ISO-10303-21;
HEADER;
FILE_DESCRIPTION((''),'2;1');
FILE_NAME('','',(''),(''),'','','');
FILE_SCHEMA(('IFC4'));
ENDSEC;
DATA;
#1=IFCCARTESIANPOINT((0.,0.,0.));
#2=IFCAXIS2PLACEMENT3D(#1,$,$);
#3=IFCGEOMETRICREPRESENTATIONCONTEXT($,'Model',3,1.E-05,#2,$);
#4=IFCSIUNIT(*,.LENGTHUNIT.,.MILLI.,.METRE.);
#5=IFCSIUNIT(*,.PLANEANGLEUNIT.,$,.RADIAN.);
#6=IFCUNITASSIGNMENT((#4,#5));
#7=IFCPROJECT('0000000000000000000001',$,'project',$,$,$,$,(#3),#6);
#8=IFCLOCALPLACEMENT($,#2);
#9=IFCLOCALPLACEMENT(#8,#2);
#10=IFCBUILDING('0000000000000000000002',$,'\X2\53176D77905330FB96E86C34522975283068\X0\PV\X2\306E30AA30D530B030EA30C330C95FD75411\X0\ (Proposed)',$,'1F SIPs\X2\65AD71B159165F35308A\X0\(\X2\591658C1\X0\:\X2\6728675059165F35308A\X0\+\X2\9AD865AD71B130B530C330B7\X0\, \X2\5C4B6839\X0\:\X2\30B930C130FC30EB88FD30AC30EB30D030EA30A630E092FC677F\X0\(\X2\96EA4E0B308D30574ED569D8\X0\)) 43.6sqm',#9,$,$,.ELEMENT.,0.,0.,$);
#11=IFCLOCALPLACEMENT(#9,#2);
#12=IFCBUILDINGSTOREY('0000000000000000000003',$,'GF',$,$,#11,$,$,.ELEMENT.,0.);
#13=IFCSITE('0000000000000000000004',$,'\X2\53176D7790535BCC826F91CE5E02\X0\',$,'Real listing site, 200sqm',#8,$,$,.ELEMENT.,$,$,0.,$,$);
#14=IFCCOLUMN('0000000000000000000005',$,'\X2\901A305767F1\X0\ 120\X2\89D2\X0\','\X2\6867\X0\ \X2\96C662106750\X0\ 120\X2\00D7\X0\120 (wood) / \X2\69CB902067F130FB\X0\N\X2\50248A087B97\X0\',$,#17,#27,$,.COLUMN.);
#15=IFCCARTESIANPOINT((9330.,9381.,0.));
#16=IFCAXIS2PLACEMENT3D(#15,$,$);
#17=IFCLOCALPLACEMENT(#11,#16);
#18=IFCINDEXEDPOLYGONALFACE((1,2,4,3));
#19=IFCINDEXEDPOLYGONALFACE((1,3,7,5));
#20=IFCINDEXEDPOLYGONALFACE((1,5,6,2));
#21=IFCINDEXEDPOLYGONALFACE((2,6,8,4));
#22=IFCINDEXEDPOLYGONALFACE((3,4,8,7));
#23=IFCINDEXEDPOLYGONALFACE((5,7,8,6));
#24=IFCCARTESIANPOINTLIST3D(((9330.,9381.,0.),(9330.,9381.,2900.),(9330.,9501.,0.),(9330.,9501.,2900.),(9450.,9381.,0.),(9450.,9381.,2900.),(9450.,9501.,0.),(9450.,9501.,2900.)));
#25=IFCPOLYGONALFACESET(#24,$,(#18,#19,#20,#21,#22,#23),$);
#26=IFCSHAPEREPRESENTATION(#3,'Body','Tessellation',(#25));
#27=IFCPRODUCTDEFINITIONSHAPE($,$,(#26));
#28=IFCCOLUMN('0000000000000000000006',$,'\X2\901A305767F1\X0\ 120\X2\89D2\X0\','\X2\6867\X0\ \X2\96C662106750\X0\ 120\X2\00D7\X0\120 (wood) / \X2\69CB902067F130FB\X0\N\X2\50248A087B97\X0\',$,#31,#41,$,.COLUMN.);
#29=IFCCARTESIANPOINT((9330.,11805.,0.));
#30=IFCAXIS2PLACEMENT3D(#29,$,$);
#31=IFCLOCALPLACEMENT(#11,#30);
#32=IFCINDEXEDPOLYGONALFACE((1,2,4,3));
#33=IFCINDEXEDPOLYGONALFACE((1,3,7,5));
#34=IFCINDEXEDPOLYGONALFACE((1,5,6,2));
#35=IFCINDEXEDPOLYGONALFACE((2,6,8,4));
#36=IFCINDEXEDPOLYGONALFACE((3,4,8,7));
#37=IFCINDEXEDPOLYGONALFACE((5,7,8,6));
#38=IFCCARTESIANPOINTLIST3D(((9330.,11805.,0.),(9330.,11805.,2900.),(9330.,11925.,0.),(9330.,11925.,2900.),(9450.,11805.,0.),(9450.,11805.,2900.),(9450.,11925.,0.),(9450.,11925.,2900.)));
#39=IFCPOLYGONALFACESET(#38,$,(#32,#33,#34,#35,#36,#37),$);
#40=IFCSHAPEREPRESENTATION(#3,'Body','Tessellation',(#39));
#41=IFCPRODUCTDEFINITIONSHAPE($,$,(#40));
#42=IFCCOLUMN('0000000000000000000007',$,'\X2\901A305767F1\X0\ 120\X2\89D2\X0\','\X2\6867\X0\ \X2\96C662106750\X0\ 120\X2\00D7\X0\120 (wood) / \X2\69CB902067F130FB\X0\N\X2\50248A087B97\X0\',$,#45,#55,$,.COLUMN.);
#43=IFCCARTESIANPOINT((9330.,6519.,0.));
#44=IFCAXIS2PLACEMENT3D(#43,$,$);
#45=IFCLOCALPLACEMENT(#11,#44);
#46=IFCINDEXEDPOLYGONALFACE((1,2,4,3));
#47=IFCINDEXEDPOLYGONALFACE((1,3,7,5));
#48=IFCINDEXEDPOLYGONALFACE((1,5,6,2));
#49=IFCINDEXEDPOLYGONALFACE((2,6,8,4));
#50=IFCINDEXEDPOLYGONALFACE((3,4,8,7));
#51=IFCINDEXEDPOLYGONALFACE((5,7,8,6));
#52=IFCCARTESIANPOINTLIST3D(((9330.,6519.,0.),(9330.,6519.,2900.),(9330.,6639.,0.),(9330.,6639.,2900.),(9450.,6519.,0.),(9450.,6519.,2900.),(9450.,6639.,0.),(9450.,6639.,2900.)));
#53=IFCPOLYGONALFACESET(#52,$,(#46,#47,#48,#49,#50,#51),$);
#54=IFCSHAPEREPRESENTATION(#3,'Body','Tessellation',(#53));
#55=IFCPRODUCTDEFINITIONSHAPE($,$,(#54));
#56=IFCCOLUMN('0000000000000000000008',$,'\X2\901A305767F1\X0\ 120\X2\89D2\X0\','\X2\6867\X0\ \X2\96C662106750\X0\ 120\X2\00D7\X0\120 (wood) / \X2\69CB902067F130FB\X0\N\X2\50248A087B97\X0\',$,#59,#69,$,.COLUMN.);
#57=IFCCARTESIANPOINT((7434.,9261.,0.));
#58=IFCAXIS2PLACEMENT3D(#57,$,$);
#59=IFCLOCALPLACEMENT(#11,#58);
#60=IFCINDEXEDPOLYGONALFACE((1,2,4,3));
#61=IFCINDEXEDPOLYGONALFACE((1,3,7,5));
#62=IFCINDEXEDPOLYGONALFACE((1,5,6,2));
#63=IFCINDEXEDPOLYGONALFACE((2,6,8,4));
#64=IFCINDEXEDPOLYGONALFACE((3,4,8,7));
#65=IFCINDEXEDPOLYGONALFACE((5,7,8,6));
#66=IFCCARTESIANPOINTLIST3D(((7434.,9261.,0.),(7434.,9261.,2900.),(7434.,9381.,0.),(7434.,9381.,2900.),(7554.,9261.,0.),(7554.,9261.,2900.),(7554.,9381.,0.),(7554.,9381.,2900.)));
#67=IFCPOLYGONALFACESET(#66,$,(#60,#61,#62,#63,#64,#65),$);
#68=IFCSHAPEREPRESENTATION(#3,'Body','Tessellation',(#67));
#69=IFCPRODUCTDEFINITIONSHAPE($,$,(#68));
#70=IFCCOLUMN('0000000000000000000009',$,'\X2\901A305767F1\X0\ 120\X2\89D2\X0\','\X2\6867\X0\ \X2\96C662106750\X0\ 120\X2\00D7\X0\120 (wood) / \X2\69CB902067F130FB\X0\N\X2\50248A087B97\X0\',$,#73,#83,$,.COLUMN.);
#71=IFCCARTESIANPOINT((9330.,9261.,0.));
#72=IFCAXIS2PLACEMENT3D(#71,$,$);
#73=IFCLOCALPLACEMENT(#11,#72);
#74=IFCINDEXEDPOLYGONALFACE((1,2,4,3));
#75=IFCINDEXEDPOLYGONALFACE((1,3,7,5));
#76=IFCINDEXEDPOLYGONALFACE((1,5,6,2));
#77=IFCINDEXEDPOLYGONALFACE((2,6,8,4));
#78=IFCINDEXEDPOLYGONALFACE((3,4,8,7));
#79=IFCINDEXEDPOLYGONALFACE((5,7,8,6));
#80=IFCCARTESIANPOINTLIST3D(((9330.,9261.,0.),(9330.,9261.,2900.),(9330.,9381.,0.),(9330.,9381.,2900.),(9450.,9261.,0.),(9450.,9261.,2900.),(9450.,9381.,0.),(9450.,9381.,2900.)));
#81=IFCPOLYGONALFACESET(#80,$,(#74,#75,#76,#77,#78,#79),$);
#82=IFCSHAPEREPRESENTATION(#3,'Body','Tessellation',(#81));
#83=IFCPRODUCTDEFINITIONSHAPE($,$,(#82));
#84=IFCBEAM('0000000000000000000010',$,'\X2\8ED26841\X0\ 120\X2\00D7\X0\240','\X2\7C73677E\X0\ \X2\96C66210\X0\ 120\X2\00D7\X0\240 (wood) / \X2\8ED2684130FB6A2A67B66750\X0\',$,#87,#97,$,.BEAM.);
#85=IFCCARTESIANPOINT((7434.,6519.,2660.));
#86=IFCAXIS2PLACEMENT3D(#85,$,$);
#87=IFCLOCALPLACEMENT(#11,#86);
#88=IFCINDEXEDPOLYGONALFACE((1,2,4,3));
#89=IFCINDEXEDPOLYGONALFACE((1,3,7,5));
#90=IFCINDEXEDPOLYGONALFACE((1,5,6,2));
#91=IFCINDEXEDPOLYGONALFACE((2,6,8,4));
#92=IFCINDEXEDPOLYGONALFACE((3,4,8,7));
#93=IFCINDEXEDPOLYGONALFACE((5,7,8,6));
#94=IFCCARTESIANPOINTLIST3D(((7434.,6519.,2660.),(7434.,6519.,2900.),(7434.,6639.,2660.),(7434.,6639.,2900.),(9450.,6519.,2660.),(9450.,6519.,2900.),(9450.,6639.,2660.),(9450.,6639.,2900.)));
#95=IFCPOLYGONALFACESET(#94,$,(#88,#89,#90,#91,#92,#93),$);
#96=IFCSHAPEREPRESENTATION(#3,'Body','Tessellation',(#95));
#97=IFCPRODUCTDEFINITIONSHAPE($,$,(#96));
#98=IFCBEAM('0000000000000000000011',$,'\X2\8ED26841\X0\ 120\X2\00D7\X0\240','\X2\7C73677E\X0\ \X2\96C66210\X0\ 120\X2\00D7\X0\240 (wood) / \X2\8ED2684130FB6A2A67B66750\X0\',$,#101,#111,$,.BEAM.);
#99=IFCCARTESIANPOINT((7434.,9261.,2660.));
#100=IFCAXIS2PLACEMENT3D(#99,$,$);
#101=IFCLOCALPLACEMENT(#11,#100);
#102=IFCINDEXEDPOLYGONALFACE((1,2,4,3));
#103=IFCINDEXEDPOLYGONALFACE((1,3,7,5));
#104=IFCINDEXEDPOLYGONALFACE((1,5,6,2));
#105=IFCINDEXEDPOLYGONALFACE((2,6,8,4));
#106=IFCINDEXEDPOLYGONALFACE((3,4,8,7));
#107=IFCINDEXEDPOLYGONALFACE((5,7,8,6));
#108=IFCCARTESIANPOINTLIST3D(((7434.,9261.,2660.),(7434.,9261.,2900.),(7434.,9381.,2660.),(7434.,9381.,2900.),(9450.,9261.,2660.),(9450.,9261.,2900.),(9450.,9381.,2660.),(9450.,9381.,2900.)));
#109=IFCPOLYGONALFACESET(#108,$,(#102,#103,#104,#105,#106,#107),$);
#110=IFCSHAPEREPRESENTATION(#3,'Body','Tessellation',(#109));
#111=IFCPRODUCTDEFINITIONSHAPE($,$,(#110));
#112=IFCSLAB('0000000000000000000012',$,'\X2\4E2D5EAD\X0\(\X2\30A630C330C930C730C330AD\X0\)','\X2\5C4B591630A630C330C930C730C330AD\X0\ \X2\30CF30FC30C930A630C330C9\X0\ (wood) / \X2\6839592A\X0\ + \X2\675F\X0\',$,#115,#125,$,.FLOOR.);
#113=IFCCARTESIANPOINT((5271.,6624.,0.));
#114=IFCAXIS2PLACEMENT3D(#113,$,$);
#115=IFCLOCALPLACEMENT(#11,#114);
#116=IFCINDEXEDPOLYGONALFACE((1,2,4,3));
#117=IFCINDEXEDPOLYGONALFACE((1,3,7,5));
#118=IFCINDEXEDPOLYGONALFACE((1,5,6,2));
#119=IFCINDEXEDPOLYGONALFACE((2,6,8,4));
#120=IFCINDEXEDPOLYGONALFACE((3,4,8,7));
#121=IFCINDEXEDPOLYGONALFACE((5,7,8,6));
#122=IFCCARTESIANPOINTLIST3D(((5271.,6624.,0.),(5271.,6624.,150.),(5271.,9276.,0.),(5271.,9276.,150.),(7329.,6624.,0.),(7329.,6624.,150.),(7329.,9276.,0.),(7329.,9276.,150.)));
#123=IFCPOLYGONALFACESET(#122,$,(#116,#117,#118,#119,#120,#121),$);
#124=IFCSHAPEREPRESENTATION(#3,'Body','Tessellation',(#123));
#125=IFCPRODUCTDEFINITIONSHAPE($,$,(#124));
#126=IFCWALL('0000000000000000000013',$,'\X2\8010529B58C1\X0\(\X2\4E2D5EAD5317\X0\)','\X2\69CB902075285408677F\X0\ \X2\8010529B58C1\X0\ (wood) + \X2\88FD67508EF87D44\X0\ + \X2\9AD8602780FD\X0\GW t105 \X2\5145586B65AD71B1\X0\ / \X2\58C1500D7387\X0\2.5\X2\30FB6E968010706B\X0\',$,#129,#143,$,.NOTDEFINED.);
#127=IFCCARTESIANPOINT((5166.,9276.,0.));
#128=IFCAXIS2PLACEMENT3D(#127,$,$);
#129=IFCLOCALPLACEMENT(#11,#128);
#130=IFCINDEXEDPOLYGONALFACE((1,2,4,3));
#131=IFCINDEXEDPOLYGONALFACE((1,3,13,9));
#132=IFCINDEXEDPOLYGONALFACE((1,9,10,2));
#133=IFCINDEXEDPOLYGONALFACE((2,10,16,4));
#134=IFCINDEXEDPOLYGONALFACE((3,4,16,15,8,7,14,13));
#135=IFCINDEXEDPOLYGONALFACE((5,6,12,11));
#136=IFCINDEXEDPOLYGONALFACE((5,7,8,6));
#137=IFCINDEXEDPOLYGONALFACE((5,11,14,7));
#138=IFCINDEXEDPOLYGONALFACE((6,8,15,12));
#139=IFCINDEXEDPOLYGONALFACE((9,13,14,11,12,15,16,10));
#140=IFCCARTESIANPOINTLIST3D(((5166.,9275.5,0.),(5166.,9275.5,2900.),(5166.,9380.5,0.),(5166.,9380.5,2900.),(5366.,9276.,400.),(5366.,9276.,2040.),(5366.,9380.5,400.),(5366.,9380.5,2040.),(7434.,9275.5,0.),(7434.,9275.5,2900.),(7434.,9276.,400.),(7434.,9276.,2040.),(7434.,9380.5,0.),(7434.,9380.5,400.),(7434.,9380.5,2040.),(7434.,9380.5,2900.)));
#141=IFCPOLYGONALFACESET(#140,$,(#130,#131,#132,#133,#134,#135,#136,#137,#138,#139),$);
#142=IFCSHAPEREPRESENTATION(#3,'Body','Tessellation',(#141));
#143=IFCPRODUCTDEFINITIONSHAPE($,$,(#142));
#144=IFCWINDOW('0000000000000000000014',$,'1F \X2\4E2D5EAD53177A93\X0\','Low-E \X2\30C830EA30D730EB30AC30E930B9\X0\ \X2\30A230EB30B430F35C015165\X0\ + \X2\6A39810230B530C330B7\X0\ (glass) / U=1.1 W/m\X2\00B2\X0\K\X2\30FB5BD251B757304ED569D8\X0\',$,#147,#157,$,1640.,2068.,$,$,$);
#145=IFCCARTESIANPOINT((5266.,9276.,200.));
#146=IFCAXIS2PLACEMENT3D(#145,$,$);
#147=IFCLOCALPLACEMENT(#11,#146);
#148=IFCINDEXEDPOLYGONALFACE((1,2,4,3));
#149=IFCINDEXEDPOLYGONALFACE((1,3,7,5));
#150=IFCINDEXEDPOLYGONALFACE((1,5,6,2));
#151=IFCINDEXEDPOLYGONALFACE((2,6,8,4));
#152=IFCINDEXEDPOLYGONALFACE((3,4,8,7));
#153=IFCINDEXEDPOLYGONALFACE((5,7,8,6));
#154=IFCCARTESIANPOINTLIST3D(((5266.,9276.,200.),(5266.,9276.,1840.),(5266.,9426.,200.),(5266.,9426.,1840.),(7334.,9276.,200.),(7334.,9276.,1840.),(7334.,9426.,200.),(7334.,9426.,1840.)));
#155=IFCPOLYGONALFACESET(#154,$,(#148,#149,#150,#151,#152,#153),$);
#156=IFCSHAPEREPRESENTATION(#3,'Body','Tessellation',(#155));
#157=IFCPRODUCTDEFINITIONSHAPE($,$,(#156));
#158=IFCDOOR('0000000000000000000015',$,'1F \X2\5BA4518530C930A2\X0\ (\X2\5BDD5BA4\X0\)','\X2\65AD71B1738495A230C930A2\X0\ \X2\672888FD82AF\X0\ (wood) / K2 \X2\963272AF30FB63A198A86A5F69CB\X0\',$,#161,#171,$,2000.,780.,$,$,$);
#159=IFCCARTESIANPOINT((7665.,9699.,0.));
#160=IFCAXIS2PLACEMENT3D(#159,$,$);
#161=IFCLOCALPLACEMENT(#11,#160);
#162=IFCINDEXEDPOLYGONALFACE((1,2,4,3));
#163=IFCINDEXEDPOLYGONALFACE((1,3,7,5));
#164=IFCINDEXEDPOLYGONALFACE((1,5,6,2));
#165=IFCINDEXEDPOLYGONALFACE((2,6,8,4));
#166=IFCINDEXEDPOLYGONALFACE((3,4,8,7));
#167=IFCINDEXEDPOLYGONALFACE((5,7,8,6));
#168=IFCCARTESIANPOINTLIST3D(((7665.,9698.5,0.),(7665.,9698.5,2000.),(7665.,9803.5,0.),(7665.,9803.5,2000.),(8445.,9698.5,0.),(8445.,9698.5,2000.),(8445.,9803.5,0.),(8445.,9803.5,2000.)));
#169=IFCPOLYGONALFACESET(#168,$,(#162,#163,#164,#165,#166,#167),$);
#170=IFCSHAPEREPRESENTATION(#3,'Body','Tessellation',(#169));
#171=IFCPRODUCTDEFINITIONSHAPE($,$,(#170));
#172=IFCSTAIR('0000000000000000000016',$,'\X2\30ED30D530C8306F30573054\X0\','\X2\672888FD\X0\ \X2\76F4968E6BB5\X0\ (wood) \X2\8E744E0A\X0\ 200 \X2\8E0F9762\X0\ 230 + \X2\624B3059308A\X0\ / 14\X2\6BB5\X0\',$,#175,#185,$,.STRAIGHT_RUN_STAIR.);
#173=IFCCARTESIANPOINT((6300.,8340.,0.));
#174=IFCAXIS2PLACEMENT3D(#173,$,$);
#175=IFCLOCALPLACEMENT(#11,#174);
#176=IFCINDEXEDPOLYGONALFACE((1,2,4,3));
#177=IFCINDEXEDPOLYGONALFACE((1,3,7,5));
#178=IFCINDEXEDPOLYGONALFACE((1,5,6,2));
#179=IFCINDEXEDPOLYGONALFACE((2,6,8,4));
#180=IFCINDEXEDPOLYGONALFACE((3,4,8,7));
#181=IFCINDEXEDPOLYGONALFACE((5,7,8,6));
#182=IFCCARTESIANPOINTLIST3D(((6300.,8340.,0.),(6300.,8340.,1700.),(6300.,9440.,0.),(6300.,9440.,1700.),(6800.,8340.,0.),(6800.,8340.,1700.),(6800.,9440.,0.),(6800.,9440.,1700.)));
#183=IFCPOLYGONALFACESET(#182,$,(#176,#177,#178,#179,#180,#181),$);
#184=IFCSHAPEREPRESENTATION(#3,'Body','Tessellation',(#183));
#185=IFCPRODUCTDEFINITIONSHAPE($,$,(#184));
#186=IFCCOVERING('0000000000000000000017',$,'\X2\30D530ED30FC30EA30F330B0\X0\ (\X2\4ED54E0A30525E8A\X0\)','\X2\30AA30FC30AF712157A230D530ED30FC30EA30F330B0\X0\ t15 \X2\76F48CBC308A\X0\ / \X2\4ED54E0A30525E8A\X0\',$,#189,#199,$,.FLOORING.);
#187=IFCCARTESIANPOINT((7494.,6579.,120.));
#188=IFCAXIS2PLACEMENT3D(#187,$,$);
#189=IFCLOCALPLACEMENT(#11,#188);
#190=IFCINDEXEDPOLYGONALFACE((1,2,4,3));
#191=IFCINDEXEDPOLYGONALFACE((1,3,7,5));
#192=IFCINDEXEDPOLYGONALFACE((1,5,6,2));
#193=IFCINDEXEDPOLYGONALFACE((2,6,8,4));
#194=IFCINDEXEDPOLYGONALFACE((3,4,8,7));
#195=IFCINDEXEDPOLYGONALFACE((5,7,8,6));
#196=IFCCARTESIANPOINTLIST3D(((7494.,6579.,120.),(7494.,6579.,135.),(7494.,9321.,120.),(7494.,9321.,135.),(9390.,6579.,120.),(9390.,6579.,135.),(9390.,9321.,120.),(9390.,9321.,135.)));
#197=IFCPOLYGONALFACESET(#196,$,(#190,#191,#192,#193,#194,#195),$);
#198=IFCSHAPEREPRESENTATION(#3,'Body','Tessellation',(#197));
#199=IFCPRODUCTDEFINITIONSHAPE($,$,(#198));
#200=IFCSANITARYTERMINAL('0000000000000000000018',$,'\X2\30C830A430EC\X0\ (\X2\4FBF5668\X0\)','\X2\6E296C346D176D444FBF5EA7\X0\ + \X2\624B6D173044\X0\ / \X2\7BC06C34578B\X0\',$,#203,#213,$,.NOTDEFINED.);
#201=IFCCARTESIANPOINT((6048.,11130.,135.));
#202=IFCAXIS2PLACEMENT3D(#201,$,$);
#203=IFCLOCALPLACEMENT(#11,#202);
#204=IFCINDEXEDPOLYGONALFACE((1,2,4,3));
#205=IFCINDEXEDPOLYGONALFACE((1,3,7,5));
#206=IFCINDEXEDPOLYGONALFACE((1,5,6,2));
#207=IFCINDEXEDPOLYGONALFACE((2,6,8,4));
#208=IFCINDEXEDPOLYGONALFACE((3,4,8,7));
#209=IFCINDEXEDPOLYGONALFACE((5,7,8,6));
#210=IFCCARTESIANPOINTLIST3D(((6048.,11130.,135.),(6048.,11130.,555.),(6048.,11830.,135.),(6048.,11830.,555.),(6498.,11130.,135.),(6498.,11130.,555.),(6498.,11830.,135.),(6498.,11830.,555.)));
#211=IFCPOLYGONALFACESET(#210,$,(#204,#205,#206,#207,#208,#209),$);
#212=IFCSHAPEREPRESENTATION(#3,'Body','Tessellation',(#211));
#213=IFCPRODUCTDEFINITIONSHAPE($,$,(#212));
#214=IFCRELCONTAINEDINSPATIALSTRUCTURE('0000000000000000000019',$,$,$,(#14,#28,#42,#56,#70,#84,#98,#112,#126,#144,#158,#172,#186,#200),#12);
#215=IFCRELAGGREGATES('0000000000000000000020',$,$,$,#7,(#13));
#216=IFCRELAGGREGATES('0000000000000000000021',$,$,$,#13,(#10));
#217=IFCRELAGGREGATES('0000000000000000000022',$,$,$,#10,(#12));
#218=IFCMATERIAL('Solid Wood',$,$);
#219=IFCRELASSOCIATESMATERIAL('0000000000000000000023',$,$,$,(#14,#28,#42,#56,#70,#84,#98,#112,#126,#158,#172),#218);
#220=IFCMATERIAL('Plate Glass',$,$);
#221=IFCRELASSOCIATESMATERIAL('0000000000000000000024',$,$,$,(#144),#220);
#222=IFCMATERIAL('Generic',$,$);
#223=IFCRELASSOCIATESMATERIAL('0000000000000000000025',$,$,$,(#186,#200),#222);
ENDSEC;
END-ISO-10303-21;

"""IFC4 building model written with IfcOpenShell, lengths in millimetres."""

from ifc_helpers import new_model, si_unit, frame, frame_2d, origin, place, context, project, spatial, rectangle, extrude, material, element, fill, save


model = new_model("IFC4")

# Units and contexts
model_context = context("Model", 3, precision=1e-05, world=origin())
ifc_project = project(units=[si_unit("LENGTHUNIT", "METRE", prefix="MILLI"), si_unit("PLANEANGLEUNIT", "RADIAN")], contexts=[model_context])

# Site, building, storey
site_placement = place(None, origin())
site = spatial("IfcSite", under=ifc_project, at=site_placement, Name="北海道富良野市", ObjectType="Real listing site, 200sqm", CompositionType="ELEMENT", RefElevation=0.0)
building_placement = place(site_placement, origin())
building = spatial("IfcBuilding", under=site, at=building_placement, Name="北海道・雨水利用とPVのオフグリッド志向 (Proposed)", ObjectType="1F SIPs断熱外張り(外壁:木材外張り+高断熱サッシ, 屋根:スチール製ガルバリウム鋼板(雪下ろし仕様)) 43.6sqm", CompositionType="ELEMENT", ElevationOfRefHeight=0.0, ElevationOfTerrain=0.0)
storey_placement = place(building_placement, origin())
storey = spatial("IfcBuildingStorey", under=building, at=storey_placement, Name="GF", CompositionType="ELEMENT", Elevation=0.0)

# Columns
ifc_material_1 = material(Name="Solid Wood")
column_1_placement = place(storey_placement, frame((9330.0, 9381.0, 0.0)))
element("IfcColumn", 1, at=column_1_placement, inside=storey, material=ifc_material_1, Name="通し柱 120角", Description="桧 集成材 120×120 (wood) / 構造柱・N値計算", PredefinedType="COLUMN", context=model_context, shape_type="SweptSolid", body=[
    extrude(rectangle(XDim=120.0, YDim=120.0, at=frame_2d((60.0, 60.0))), frame((9330.0, 9381.0, 0.0)), (0.0, 0.0, 1.0), 2900.0),
])
column_2_placement = place(storey_placement, frame((9330.0, 11805.0, 0.0)))
element("IfcColumn", 2, at=column_2_placement, inside=storey, material=ifc_material_1, Name="通し柱 120角", Description="桧 集成材 120×120 (wood) / 構造柱・N値計算", PredefinedType="COLUMN", context=model_context, shape_type="SweptSolid", body=[
    extrude(rectangle(XDim=120.0, YDim=120.0, at=frame_2d((60.0, 60.0))), frame((9330.0, 11805.0, 0.0)), (0.0, 0.0, 1.0), 2900.0),
])
column_3_placement = place(storey_placement, frame((9330.0, 6519.0, 0.0)))
element("IfcColumn", 3, at=column_3_placement, inside=storey, material=ifc_material_1, Name="通し柱 120角", Description="桧 集成材 120×120 (wood) / 構造柱・N値計算", PredefinedType="COLUMN", context=model_context, shape_type="SweptSolid", body=[
    extrude(rectangle(XDim=120.0, YDim=120.0, at=frame_2d((60.0, 60.0))), frame((9330.0, 6519.0, 0.0)), (0.0, 0.0, 1.0), 2900.0),
])
column_4_placement = place(storey_placement, frame((7434.0, 9261.0, 0.0)))
element("IfcColumn", 4, at=column_4_placement, inside=storey, material=ifc_material_1, Name="通し柱 120角", Description="桧 集成材 120×120 (wood) / 構造柱・N値計算", PredefinedType="COLUMN", context=model_context, shape_type="SweptSolid", body=[
    extrude(rectangle(XDim=120.0, YDim=120.0, at=frame_2d((60.0, 60.0))), frame((7434.0, 9261.0, 0.0)), (0.0, 0.0, 1.0), 2900.0),
])
column_5_placement = place(storey_placement, frame((9330.0, 9261.0, 0.0)))
element("IfcColumn", 5, at=column_5_placement, inside=storey, material=ifc_material_1, Name="通し柱 120角", Description="桧 集成材 120×120 (wood) / 構造柱・N値計算", PredefinedType="COLUMN", context=model_context, shape_type="SweptSolid", body=[
    extrude(rectangle(XDim=120.0, YDim=120.0, at=frame_2d((60.0, 60.0))), frame((9330.0, 9261.0, 0.0)), (0.0, 0.0, 1.0), 2900.0),
])

# Beams
beam_1_placement = place(storey_placement, frame((7434.0, 6519.0, 2660.0)))
element("IfcBeam", 6, at=beam_1_placement, inside=storey, material=ifc_material_1, Name="軒桁 120×240", Description="米松 集成 120×240 (wood) / 軒桁・横架材", PredefinedType="BEAM", context=model_context, shape_type="SweptSolid", body=[
    extrude(rectangle(XDim=2016.0, YDim=120.0, at=frame_2d((1008.0, 60.0))), frame((7434.0, 6519.0, 2660.0)), (0.0, 0.0, 1.0), 240.0),
])
beam_2_placement = place(storey_placement, frame((7434.0, 9261.0, 2660.0)))
element("IfcBeam", 7, at=beam_2_placement, inside=storey, material=ifc_material_1, Name="軒桁 120×240", Description="米松 集成 120×240 (wood) / 軒桁・横架材", PredefinedType="BEAM", context=model_context, shape_type="SweptSolid", body=[
    extrude(rectangle(XDim=2016.0, YDim=120.0, at=frame_2d((1008.0, 60.0))), frame((7434.0, 9261.0, 2660.0)), (0.0, 0.0, 1.0), 240.0),
])

# Slab
slab_placement = place(storey_placement, frame((5271.0, 6624.0, 0.0)))
element("IfcSlab", 8, at=slab_placement, inside=storey, material=ifc_material_1, Name="中庭(ウッドデッキ)", Description="屋外ウッドデッキ ハードウッド (wood) / 根太 + 束", PredefinedType="FLOOR", context=model_context, shape_type="SweptSolid", body=[
    extrude(rectangle(XDim=2058.0, YDim=2652.0, at=frame_2d((1029.0, 1326.0))), frame((5271.0, 6624.0, 0.0)), (0.0, 0.0, 1.0), 150.0),
])

# Wall, opening, window
wall_1_placement = place(storey_placement, frame((5166.0, 9276.0, 0.0)))
wall_1 = element("IfcWall", 9, at=wall_1_placement, inside=storey, material=ifc_material_1, Name="耐力壁(中庭北)", Description="構造用合板 耐力壁 (wood) + 製材軸組 + 高性能GW t105 充填断熱 / 壁倍率2.5・準耐火", PredefinedType="NOTDEFINED", context=model_context, shape_type="SweptSolid", body=[
    extrude(rectangle(XDim=2268.0, YDim=105.0, at=frame_2d((1134.0, 52.0))), frame((5166.0, 9276.0, 0.0)), (0.0, 0.0, 1.0), 2900.0),
])
opening_placement = place(storey_placement, frame((5266.0, 9276.0, 200.0)))
opening = element("IfcOpeningElement", 10, at=opening_placement, cuts=wall_1, PredefinedType="NOTDEFINED", context=model_context, shape_type="SweptSolid", body=[
    extrude(rectangle(XDim=2068.0, YDim=150.0, at=frame_2d((1034.0, 75.0))), frame((5266.0, 9276.0, 200.0)), (0.0, 0.0, 1.0), 1640.0),
])
ifc_material_2 = material(Name="Plate Glass")
window_placement = place(storey_placement, frame((5266.0, 9276.0, 200.0)))
window = element("IfcWindow", 11, at=window_placement, inside=storey, material=ifc_material_2, Name="1F 中庭北窓", Description="Low-E トリプルガラス アルゴン封入 + 樹脂サッシ (glass) / U=1.1 W/m²K・寒冷地仕様", OverallHeight=1640.0, OverallWidth=2068.0, context=model_context, shape_type="SweptSolid", body=[
    extrude(rectangle(XDim=2068.0, YDim=150.0, at=frame_2d((1034.0, 75.0))), frame((5266.0, 9276.0, 200.0)), (0.0, 0.0, 1.0), 1640.0),
])
fill(opening, window)

# Door
door_placement = place(storey_placement, frame((7665.0, 9699.0, 0.0)))
element("IfcDoor", 12, at=door_placement, inside=storey, material=ifc_material_1, Name="1F 室内ドア (寝室)", Description="断熱玄関ドア 木製芯 (wood) / K2 防犯・採風機構", OverallHeight=2000.0, OverallWidth=780.0, context=model_context, shape_type="SweptSolid", body=[
    extrude(rectangle(XDim=780.0, YDim=105.0, at=frame_2d((390.0, 52.0))), frame((7665.0, 9699.0, 0.0)), (0.0, 0.0, 1.0), 2000.0),
])

# Stair
stair_placement = place(storey_placement, frame((6300.0, 8340.0, 0.0)))
element("IfcStair", 13, at=stair_placement, inside=storey, material=ifc_material_1, Name="ロフトはしご", Description="木製 直階段 (wood) 蹴上 200 踏面 230 + 手すり / 14段", PredefinedType="STRAIGHT_RUN_STAIR", context=model_context, shape_type="SweptSolid", body=[
    extrude(rectangle(XDim=500.0, YDim=1100.0, at=frame_2d((250.0, 550.0))), frame((6300.0, 8340.0, 0.0)), (0.0, 0.0, 1.0), 1700.0),
])

# Covering
ifc_material_3 = material(Name="Generic")
covering_placement = place(storey_placement, frame((7494.0, 6579.0, 120.0)))
element("IfcCovering", 14, at=covering_placement, inside=storey, material=ifc_material_3, Name="フローリング (仕上げ床)", Description="オーク無垢フローリング t15 直貼り / 仕上げ床", PredefinedType="FLOORING", context=model_context, shape_type="SweptSolid", body=[
    extrude(rectangle(XDim=1896.0, YDim=2742.0, at=frame_2d((948.0, 1371.0))), frame((7494.0, 6579.0, 120.0)), (0.0, 0.0, 1.0), 15.0),
])

# Sanitary terminal
sanitary_terminal_placement = place(storey_placement, frame((6048.0, 11130.0, 135.0)))
element("IfcSanitaryTerminal", 15, at=sanitary_terminal_placement, inside=storey, material=ifc_material_3, Name="トイレ (便器)", Description="温水洗浄便座 + 手洗い / 節水型", PredefinedType="NOTDEFINED", context=model_context, shape_type="SweptSolid", body=[
    extrude(rectangle(XDim=450.0, YDim=700.0, at=frame_2d((225.0, 350.0))), frame((6048.0, 11130.0, 135.0)), (0.0, 0.0, 1.0), 420.0),
])

save(model, "model.ifc")
